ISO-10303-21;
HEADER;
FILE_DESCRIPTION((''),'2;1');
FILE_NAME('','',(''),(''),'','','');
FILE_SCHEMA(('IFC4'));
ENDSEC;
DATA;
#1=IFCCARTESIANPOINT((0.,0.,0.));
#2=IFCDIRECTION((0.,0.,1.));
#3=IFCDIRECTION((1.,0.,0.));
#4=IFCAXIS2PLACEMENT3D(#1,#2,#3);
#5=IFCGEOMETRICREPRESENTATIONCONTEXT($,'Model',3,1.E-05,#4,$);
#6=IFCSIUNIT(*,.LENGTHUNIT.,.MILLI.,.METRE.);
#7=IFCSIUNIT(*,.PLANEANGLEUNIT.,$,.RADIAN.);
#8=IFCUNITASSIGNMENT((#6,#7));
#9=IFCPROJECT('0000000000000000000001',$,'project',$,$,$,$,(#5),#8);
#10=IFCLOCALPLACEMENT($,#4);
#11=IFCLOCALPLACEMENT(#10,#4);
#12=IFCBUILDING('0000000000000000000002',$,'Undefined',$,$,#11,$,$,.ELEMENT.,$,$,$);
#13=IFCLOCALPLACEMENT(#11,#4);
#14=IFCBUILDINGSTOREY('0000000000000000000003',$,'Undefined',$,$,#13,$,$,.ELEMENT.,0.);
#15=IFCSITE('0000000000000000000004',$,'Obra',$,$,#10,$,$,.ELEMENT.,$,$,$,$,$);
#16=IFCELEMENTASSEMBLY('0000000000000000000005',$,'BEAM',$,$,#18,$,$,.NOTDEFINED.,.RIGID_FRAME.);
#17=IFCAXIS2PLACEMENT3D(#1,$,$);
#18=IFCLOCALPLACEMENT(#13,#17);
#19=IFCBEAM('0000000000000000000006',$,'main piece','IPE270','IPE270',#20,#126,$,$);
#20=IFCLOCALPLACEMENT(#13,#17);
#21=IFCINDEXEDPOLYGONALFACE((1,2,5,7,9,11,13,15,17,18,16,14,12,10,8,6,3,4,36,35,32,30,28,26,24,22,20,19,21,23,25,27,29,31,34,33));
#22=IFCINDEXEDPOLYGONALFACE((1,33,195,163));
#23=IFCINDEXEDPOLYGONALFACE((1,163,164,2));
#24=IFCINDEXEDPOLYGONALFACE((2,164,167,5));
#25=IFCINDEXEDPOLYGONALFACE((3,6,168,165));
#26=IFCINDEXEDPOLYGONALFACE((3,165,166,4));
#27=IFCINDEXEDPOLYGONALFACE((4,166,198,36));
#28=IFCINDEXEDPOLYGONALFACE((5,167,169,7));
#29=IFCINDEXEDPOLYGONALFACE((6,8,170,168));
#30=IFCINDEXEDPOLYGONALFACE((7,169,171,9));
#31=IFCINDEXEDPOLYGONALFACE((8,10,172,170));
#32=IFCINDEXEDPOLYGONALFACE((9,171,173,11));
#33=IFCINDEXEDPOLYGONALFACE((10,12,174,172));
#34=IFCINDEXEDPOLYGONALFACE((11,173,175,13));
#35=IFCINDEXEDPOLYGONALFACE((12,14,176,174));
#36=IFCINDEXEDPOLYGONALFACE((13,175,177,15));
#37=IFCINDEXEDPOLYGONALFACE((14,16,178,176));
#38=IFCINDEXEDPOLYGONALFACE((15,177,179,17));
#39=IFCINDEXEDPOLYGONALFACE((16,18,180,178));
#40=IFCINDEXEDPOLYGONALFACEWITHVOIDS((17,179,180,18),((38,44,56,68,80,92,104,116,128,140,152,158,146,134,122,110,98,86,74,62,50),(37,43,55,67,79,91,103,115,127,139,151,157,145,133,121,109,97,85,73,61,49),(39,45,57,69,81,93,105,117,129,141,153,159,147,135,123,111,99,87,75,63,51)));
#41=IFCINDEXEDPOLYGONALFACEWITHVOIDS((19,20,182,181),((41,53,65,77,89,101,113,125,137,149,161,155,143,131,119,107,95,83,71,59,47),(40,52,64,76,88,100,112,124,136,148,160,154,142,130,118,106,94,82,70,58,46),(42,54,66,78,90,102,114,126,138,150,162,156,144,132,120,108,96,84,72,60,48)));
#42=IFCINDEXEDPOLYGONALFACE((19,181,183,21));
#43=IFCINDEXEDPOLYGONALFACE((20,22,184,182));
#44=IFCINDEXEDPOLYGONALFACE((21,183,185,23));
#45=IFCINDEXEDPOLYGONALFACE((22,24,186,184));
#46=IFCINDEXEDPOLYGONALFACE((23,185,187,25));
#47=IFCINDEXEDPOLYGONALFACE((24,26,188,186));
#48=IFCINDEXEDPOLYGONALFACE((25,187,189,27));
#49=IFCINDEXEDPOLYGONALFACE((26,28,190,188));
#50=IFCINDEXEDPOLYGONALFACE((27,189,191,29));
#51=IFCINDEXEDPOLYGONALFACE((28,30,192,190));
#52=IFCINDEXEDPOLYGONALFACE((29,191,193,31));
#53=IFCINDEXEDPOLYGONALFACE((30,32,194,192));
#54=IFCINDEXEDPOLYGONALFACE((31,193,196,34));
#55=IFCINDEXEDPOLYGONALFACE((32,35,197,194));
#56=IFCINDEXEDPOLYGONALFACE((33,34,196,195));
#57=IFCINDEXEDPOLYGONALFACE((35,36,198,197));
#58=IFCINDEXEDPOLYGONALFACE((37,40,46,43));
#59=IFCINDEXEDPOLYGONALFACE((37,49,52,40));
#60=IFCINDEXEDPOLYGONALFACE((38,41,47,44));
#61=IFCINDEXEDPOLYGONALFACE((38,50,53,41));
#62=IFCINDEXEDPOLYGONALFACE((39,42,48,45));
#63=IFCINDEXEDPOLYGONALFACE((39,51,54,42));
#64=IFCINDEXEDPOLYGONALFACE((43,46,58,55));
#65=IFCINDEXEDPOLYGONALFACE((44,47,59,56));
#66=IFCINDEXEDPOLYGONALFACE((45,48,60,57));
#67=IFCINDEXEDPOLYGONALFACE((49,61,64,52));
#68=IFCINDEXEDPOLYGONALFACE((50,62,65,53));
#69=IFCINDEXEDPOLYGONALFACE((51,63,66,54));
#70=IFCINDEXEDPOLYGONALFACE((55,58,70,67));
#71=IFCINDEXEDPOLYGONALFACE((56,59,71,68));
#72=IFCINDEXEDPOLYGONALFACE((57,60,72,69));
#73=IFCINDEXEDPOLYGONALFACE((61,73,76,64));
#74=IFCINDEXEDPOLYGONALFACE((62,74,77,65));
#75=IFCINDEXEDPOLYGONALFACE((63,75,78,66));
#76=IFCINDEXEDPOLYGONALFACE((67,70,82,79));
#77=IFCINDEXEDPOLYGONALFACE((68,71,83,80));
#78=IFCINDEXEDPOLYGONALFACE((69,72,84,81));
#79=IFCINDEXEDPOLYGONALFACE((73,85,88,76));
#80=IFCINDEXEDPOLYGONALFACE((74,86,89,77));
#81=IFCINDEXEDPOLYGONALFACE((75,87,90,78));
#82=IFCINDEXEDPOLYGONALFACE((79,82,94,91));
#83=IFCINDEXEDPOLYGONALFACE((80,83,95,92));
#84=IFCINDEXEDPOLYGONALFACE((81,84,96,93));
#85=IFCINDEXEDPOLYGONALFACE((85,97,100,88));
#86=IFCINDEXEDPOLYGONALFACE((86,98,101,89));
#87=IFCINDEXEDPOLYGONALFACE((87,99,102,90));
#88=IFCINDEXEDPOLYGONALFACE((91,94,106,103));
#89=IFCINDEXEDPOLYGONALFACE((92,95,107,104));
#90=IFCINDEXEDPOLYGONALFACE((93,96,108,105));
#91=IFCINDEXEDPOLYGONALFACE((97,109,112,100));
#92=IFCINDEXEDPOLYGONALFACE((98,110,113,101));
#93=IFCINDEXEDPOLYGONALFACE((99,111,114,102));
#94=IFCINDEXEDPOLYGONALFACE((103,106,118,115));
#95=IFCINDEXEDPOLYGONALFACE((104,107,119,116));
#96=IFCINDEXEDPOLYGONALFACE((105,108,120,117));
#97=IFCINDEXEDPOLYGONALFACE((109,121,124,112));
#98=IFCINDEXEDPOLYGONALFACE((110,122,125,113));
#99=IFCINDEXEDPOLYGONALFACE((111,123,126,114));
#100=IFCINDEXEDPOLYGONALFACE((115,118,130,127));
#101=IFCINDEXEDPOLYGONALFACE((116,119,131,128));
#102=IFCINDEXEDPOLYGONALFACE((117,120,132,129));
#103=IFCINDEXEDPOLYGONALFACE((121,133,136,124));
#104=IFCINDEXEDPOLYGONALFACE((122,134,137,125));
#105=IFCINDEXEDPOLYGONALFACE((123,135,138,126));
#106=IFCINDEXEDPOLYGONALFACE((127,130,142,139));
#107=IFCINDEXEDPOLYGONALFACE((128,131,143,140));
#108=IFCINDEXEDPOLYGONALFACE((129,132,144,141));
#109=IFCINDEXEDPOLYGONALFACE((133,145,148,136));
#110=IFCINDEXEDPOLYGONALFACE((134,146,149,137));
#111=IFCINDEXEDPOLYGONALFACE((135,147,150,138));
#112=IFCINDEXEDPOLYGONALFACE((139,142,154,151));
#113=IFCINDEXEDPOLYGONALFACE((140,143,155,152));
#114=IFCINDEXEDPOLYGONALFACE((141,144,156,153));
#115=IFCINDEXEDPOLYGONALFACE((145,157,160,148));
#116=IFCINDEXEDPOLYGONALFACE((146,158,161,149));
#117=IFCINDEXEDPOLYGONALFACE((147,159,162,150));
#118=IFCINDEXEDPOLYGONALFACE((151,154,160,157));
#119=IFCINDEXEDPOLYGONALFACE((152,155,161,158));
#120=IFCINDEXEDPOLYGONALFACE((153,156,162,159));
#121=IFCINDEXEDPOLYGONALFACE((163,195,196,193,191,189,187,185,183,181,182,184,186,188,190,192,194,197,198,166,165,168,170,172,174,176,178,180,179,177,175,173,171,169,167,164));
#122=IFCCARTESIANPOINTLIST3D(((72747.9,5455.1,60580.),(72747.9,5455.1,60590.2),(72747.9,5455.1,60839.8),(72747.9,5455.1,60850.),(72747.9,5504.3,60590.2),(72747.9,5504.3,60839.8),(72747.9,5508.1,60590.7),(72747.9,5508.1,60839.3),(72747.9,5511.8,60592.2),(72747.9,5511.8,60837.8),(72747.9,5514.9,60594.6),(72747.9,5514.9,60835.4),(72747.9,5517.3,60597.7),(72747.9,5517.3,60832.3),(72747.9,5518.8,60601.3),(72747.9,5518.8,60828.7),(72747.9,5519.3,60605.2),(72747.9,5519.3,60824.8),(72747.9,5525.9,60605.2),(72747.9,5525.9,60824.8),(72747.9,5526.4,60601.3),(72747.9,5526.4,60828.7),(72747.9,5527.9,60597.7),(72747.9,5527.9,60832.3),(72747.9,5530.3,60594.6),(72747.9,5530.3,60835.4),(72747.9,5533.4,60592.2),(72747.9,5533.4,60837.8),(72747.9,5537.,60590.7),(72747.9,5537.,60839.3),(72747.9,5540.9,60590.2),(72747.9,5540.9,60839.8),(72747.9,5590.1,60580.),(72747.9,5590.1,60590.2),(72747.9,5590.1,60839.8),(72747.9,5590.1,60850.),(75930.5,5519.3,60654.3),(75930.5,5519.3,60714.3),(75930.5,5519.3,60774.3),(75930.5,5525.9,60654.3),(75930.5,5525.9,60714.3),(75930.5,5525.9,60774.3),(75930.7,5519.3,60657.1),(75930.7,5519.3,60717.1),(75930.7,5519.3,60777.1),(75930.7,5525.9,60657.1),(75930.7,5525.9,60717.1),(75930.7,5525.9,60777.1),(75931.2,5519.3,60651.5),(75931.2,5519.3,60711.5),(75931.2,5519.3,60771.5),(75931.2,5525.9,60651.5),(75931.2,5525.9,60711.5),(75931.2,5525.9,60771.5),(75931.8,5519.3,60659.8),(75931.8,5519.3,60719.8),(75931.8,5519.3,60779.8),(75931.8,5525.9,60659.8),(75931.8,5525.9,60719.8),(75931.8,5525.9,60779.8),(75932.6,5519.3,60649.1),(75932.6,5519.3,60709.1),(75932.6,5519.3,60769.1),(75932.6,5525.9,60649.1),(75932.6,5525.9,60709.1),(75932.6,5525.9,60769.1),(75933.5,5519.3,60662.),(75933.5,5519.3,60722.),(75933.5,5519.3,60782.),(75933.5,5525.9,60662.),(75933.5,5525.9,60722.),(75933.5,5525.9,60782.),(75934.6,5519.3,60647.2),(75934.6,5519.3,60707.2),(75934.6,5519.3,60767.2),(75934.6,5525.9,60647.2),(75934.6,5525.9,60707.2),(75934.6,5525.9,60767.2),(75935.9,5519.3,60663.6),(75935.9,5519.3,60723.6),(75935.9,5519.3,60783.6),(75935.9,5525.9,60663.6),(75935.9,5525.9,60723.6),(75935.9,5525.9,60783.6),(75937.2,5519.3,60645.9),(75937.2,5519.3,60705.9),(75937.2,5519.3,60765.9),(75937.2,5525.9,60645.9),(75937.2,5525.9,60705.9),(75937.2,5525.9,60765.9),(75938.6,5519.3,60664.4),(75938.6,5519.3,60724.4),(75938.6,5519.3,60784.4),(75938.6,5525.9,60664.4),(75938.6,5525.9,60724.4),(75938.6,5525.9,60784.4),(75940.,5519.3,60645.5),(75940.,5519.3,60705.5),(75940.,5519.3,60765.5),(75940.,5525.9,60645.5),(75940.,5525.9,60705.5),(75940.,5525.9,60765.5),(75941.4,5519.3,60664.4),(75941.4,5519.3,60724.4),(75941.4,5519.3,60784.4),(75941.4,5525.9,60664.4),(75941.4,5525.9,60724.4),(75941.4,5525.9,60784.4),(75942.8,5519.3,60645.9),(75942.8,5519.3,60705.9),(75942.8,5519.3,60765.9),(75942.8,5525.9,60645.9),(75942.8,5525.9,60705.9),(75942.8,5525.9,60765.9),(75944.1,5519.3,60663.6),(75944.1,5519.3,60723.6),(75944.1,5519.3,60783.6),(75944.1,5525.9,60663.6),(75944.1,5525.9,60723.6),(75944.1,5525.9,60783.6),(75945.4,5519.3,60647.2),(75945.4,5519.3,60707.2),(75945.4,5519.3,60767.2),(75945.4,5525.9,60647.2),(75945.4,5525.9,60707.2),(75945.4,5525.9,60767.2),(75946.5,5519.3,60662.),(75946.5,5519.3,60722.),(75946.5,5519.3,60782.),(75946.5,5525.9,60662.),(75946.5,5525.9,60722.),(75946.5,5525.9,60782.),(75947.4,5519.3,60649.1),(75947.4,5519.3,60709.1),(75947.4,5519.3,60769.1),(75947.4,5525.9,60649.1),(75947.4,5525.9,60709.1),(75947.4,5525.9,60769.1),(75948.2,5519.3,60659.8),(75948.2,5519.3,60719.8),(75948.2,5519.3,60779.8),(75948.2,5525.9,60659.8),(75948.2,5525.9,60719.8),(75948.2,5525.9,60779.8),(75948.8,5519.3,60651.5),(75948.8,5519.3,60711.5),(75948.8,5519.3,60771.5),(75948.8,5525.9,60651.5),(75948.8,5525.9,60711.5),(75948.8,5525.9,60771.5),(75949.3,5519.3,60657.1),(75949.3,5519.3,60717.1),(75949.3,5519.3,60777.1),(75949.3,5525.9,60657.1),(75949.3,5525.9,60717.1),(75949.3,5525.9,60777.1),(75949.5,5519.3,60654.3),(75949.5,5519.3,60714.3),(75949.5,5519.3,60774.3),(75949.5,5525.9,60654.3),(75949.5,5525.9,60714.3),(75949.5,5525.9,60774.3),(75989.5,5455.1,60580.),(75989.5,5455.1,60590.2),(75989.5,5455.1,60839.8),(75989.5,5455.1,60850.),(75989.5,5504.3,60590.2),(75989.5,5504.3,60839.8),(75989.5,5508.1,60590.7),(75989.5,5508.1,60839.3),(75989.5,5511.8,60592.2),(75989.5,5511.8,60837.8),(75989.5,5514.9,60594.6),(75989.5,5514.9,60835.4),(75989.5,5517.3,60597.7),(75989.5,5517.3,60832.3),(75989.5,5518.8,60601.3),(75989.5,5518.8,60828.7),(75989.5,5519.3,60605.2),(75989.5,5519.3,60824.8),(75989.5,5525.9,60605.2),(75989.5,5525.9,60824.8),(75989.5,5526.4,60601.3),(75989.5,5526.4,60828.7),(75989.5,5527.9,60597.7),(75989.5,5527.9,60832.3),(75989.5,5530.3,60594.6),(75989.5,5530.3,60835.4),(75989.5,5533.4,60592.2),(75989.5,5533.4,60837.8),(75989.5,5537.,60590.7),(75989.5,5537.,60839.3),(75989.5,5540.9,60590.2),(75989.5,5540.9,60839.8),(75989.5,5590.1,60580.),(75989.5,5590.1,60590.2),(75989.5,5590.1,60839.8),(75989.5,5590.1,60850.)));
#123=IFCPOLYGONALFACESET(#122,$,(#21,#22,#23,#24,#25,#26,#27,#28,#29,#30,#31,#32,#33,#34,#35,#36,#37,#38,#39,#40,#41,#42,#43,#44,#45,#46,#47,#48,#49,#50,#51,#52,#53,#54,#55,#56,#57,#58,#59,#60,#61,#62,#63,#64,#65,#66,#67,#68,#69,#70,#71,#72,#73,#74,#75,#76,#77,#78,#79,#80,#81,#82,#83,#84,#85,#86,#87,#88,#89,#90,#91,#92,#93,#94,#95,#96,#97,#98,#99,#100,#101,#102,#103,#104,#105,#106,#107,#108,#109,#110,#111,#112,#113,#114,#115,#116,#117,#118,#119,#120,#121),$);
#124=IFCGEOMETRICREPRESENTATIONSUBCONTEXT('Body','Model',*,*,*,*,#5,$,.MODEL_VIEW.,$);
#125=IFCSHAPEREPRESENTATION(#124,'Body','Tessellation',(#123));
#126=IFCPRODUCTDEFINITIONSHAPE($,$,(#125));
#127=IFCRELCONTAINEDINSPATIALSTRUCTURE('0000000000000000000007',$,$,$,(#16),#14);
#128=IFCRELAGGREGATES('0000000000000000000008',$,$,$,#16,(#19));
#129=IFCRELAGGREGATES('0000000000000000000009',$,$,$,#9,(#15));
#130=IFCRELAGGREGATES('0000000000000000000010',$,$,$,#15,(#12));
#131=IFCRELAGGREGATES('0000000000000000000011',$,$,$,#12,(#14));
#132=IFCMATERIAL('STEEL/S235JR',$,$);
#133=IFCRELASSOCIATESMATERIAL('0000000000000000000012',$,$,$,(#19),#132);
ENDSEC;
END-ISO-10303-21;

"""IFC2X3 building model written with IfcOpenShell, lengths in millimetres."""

from ifc_helpers import new_model, si_unit, frame, origin_with_axes, origin_2d_with_axis, place, context, subcontext, project, spatial, circle, i_section, extrude, clip, halfspace, source, transform, mapped, material, element, aggregate, save


model = new_model("IFC2X3")

# Units and contexts
model_context = context("Model", 3, precision=1e-05, world=origin_with_axes())
body_context = subcontext(model_context, "Body", "Model", "MODEL_VIEW")
ifc_project = project(units=[si_unit("LENGTHUNIT", "METRE", prefix="MILLI"), si_unit("PLANEANGLEUNIT", "RADIAN")], contexts=[model_context])

# Site, building, storey
site_placement = place(None, origin_with_axes())
site = spatial("IfcSite", under=ifc_project, at=site_placement, Name="Obra", CompositionType="ELEMENT")
building_placement = place(site_placement, origin_with_axes())
building = spatial("IfcBuilding", under=site, at=building_placement, Name="Undefined", CompositionType="ELEMENT")
storey_placement = place(building_placement, origin_with_axes())
storey = spatial("IfcBuildingStorey", under=building, at=storey_placement, Name="Undefined", CompositionType="ELEMENT", Elevation=0.0)

# Shared definitions
ifc_material_1 = material(Name="STEEL/S235JR")

# Element assembly, beam, opening
assembly_1_placement = place(storey_placement, origin_with_axes())
assembly_1 = element("IfcElementAssembly", 1, at=assembly_1_placement, inside=storey, Name="BEAM", AssemblyPlace="NOTDEFINED", PredefinedType="RIGID_FRAME")
beam_1_placement = place(assembly_1_placement, frame((72747.9, 5522.6, 60715.0), z_axis=(0.0, 0.0, 1.0), x_axis=(1.0, 0.0, 0.0)))
beam_1 = element("IfcBeam", 2, at=beam_1_placement, material=ifc_material_1, Name="main piece", Description="IPE270", ObjectType="IPE270", context=body_context, shape_type="Clipping", body=[
    clip(extrude(i_section(OverallWidth=135.0, OverallDepth=270.0, WebThickness=6.6, FlangeThickness=10.2, FilletRadius=15.0, at=origin_2d_with_axis()), frame((3352.2, 0.0, 0.0), z_axis=(-1.0, 0.0, 0.0), x_axis=(0.0, -1.0, 0.0)), (0.0, 0.0, 1.0), 3352.2), halfspace(frame((3241.7, -60.0, -120.0), z_axis=(1.0, 0.000019, 0.0), x_axis=(0.0, 0.0, 1.0)), False)),
])
shared_shape_1 = source(origin_with_axes(), body_context, "Body", "SweptSolid", [
    extrude(circle(Radius=9.5, at=origin_2d_with_axis()), frame((0.0, -3.4, 0.0), z_axis=(0.0, 1.0, 0.0), x_axis=(1.0, 0.0, 0.0)), (0.0, 0.0, 1.0), 6.8),
])
opening_1_placement = place(assembly_1_placement, frame((75990.0, 5522.6, 60835.0), z_axis=(-1.0, 0.0, 0.0), x_axis=(0.0, 0.0, -1.0)))
element("IfcOpeningElement", 3, at=opening_1_placement, cuts=beam_1, ObjectType="Opening", context=body_context, shape_type="MappedRepresentation", body=[
    mapped(shared_shape_1, transform((60.0, 0.0, 50.0))),
    mapped(shared_shape_1, transform((120.0, 0.0, 50.0))),
    mapped(shared_shape_1, transform((180.0, 0.0, 50.0))),
])
aggregate(assembly_1, [beam_1])

save(model, "model.ifc")
